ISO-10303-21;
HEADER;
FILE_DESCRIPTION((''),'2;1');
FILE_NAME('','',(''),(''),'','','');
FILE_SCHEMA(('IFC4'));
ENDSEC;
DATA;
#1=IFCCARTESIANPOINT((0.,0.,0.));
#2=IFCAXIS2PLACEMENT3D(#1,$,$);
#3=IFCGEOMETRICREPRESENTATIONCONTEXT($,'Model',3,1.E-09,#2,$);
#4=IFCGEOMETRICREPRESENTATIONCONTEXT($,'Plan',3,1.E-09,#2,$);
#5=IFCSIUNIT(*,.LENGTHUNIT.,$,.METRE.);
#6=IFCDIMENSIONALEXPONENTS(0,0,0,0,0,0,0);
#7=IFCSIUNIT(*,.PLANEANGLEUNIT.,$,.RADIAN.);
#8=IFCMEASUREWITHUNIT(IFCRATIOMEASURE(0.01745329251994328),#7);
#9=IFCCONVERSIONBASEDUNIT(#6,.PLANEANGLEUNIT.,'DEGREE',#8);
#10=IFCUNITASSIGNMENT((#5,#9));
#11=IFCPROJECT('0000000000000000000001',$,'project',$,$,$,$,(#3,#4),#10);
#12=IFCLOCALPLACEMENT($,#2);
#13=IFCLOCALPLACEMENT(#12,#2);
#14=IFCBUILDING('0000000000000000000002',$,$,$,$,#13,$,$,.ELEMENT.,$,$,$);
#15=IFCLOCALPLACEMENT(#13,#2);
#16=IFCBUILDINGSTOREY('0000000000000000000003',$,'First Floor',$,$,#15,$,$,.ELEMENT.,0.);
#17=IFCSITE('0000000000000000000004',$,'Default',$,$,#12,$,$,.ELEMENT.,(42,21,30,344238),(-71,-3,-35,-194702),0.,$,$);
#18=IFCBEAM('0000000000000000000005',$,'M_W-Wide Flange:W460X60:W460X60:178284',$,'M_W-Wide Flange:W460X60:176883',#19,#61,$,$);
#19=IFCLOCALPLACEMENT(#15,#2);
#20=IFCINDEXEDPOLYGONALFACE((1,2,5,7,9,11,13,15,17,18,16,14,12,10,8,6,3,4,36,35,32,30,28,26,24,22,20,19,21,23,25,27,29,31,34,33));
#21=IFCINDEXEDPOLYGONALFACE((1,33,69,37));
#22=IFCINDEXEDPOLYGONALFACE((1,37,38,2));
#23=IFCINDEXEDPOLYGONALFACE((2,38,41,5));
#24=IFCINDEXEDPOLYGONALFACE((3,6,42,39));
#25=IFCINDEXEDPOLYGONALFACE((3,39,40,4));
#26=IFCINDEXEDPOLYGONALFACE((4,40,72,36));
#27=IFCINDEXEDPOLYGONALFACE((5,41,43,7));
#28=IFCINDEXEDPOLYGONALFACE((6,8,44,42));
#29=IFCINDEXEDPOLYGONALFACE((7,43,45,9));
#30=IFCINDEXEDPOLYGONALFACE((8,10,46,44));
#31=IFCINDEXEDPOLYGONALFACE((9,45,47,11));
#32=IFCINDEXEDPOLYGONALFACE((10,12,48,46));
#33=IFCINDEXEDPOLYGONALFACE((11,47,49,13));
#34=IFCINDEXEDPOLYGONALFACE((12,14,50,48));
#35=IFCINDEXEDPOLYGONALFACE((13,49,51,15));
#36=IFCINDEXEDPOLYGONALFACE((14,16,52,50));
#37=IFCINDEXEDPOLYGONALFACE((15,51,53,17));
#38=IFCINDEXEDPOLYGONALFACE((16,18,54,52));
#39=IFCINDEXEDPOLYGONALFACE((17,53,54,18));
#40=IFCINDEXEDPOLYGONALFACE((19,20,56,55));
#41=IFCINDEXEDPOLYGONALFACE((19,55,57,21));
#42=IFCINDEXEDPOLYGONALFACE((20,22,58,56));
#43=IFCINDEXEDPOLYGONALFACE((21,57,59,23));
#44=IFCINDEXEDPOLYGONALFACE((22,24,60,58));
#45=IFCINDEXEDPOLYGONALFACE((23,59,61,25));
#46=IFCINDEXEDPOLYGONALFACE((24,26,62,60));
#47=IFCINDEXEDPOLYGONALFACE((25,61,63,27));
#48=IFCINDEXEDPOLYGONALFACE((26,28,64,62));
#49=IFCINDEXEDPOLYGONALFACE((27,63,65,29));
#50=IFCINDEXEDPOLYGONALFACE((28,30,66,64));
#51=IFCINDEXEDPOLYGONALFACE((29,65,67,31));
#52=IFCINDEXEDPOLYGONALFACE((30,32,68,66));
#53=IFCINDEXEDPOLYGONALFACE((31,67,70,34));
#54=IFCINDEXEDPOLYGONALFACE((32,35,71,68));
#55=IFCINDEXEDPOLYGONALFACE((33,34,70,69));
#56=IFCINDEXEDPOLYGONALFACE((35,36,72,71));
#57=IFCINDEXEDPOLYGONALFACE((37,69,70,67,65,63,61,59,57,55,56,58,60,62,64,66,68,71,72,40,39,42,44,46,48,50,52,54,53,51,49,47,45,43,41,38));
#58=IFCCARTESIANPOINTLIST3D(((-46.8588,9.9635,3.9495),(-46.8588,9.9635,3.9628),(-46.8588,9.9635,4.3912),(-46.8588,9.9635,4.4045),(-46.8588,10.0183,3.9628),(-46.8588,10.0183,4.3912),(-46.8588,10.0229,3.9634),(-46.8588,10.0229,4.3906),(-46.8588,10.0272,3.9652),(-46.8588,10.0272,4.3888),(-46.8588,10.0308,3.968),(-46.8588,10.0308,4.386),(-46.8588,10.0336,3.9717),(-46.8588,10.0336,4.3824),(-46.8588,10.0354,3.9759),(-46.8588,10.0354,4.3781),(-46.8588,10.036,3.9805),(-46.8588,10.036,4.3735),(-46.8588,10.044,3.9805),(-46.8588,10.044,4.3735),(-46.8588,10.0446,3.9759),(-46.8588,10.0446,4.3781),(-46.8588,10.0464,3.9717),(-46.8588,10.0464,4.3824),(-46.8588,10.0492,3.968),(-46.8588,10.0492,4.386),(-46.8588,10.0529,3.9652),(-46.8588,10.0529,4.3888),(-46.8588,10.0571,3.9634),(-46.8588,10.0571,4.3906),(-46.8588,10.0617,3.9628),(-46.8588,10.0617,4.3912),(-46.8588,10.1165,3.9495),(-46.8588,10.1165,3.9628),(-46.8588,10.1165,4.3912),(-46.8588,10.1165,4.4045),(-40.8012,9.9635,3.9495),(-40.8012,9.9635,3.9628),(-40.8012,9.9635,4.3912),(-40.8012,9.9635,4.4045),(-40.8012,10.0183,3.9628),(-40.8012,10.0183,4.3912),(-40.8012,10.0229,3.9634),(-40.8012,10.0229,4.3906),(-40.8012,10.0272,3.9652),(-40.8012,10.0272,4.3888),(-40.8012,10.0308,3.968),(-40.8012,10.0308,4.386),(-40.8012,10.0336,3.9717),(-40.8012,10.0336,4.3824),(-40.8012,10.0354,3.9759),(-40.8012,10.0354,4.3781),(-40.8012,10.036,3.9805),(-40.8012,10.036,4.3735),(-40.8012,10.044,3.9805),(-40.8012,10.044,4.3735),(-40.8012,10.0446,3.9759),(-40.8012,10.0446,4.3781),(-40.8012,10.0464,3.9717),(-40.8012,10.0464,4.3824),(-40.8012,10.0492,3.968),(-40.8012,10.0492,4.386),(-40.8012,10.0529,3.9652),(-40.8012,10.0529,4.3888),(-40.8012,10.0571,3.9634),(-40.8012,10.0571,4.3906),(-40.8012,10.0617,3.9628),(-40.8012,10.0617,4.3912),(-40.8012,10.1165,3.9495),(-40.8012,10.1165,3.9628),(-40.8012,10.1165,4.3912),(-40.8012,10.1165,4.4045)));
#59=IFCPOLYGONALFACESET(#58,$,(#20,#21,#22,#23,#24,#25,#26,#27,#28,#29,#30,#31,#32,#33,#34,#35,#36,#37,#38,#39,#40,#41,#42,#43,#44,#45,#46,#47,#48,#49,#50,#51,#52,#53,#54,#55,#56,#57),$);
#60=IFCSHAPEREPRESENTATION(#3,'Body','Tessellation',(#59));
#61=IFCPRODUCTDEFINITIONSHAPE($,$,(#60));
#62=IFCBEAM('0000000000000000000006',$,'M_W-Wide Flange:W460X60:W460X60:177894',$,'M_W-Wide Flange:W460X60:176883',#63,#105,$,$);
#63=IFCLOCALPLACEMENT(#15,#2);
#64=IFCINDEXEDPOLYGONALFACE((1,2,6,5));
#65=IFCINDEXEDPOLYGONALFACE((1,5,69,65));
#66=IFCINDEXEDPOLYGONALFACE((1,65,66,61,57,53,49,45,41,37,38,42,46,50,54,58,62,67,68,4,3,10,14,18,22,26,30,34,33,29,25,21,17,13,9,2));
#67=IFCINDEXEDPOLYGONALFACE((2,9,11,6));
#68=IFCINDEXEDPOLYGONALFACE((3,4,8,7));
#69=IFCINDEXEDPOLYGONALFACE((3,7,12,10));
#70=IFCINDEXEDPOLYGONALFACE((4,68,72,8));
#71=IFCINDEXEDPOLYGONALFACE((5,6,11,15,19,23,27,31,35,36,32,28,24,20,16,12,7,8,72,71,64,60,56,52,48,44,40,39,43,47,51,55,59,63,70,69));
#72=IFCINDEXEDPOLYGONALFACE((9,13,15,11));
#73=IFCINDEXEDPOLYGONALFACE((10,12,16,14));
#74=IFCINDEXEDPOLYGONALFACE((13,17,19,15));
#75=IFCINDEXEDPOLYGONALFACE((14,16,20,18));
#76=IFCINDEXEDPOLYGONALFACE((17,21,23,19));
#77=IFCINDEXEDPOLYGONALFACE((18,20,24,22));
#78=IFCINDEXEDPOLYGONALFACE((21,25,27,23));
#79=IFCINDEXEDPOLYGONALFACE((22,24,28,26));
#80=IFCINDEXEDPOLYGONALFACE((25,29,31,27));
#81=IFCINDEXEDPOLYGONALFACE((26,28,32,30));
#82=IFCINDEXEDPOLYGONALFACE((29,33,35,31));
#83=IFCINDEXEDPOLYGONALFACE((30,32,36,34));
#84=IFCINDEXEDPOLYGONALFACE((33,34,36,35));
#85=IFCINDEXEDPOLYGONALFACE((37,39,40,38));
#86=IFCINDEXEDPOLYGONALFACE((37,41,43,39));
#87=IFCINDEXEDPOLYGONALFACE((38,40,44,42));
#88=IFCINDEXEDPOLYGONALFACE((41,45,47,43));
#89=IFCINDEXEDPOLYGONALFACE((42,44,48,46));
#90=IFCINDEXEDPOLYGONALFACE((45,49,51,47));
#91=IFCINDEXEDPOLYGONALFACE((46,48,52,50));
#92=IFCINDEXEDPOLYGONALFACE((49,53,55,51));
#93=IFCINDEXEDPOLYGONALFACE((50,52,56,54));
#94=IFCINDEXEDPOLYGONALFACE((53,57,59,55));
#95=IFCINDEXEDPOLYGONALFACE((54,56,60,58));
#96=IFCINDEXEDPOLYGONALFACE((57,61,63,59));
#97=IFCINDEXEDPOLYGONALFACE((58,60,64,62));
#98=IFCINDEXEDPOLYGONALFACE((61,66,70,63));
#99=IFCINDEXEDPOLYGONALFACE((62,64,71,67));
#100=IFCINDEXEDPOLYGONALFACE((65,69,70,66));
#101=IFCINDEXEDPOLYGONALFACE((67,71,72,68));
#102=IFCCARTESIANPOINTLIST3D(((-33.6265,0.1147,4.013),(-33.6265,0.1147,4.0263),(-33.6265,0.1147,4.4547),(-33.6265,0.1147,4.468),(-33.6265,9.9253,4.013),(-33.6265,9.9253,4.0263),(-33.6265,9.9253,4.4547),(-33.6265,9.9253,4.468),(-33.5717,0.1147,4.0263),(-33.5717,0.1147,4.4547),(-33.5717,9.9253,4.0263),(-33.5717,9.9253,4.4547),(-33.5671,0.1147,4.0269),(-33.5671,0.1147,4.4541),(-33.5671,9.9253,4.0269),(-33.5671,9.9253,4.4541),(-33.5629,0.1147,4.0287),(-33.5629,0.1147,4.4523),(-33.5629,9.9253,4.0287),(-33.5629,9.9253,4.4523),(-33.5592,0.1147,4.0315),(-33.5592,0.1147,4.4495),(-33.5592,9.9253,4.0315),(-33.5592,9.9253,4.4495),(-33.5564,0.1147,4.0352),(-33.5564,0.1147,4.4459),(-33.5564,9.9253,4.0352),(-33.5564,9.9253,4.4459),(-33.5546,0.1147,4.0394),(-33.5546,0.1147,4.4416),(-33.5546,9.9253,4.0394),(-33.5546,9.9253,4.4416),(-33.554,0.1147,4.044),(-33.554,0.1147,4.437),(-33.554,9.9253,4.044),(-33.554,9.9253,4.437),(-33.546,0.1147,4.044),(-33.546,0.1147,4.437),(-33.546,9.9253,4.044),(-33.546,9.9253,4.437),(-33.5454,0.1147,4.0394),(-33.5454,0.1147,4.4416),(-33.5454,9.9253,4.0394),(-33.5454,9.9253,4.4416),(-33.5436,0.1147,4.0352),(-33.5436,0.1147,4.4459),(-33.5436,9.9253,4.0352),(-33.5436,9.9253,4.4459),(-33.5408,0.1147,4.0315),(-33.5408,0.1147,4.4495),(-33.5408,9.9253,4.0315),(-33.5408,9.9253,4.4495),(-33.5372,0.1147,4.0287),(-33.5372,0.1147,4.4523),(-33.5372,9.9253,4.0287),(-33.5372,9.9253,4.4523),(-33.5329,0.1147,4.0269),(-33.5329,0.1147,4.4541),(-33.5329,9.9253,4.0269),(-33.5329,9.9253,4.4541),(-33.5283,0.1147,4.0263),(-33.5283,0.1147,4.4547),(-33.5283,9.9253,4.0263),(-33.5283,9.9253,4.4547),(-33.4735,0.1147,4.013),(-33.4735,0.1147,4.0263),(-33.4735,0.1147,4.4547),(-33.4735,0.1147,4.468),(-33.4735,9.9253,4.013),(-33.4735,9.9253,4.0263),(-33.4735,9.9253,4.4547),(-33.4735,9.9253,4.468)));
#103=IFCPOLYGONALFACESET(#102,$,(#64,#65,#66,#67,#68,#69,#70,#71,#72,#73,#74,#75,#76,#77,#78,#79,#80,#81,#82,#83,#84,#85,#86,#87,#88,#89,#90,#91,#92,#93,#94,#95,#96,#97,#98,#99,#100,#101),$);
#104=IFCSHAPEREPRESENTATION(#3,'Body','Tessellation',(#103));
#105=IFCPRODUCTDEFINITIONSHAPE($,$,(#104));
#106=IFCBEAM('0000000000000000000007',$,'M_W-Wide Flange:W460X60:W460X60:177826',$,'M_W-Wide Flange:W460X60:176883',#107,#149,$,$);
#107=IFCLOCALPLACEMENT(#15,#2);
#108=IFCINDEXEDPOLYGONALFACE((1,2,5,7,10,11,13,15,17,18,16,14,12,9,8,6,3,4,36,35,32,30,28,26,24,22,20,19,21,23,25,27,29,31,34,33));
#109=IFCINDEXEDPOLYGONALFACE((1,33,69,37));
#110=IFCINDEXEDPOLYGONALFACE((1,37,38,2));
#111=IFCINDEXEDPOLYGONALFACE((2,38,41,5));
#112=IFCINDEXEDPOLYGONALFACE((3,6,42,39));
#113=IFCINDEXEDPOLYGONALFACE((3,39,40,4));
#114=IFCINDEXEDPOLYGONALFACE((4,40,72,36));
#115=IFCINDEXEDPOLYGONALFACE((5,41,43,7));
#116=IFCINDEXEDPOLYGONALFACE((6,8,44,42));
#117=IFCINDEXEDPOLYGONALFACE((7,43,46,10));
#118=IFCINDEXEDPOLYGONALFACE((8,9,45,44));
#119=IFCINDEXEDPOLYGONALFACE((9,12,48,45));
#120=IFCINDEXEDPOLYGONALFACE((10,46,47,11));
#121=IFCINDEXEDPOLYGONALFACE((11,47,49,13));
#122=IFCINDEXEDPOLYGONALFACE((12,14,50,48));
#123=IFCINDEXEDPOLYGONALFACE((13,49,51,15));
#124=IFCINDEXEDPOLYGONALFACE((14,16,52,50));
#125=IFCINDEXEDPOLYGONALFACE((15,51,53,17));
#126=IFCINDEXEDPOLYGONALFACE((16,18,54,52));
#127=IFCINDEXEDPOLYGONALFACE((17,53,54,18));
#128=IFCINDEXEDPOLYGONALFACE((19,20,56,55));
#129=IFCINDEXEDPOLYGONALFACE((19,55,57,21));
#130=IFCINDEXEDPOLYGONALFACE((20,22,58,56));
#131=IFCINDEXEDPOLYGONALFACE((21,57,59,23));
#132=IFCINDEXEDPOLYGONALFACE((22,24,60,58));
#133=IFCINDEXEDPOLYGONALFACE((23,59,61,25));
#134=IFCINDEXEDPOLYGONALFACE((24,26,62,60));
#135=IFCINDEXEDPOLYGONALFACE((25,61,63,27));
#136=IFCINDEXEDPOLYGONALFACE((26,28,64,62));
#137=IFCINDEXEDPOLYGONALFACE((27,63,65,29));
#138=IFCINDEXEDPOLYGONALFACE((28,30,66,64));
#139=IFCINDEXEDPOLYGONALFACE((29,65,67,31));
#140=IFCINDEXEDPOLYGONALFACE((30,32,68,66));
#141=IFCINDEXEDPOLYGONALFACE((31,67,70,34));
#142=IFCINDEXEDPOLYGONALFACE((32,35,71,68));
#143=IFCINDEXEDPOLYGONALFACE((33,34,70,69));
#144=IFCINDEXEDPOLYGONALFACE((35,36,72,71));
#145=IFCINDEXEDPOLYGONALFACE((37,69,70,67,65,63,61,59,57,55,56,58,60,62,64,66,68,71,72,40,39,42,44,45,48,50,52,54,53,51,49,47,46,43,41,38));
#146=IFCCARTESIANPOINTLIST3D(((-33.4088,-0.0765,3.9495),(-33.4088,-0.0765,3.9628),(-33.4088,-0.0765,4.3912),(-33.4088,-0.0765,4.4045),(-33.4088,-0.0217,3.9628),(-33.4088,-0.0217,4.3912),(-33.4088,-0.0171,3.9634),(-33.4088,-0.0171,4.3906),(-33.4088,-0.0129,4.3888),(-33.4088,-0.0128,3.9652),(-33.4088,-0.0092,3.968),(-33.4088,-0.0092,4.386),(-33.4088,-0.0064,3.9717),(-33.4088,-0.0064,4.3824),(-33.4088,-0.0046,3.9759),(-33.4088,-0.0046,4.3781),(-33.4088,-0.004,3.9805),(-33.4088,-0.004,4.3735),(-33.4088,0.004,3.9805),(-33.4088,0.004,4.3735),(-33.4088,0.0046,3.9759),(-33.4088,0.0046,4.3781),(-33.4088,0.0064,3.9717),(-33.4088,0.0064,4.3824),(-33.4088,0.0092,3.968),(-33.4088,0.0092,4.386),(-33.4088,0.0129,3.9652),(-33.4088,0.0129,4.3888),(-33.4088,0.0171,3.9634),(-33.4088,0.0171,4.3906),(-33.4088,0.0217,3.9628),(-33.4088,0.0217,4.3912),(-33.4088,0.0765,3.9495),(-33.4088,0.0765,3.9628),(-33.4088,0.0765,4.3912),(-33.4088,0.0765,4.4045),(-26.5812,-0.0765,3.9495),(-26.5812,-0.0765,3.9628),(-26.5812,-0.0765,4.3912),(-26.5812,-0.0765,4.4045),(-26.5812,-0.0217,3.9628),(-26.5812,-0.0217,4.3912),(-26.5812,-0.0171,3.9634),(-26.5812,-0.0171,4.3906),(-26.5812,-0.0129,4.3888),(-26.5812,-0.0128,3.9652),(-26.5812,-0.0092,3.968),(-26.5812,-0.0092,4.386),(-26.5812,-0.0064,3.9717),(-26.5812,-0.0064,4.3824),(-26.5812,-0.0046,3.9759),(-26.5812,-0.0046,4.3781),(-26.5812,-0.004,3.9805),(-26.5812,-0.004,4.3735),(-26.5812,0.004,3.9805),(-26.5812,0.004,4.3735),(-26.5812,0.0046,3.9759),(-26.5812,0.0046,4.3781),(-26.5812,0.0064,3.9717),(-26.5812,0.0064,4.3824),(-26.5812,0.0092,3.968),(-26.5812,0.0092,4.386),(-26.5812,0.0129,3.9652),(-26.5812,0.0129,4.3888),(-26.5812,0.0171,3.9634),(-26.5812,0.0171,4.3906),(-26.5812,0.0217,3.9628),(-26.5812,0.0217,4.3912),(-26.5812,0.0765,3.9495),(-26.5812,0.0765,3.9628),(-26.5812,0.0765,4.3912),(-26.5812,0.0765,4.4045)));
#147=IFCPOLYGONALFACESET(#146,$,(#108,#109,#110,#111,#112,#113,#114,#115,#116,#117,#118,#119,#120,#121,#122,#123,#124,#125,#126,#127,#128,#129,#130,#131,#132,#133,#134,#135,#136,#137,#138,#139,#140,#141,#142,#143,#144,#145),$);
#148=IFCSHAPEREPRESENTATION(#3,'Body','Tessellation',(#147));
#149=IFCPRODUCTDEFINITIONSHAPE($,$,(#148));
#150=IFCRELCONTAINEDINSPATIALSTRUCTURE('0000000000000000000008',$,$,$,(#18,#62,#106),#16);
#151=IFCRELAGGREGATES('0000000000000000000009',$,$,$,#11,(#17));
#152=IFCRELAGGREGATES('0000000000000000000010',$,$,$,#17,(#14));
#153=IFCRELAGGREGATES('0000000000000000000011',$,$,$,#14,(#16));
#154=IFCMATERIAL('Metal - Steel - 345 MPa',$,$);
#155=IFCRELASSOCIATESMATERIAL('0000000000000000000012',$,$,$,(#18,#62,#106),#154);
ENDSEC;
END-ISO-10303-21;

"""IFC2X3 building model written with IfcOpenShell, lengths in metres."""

from ifc_helpers import new_model, entity, si_unit, converted_unit, frame, frame_2d, origin, place, context, project, spatial, polyline, circle_curve, parameter, trimmed, segment, composite_curve, outline, extrude, material, element, save


model = new_model("IFC2X3")

# Units and contexts
model_context = context("Model", 3, precision=1e-09, world=origin())
plan_context = context("Plan", 3, precision=1e-09, world=origin())
ifc_project = project(units=[si_unit("LENGTHUNIT", "METRE"), converted_unit("PLANEANGLEUNIT", "DEGREE", entity("IfcRatioMeasure", 0.01745329251994328), si_unit("PLANEANGLEUNIT", "RADIAN"), dimensions=[0, 0, 0, 0, 0, 0, 0])], contexts=[model_context, plan_context])

# Site, building, storey
site_placement = place(None, origin())
site = spatial("IfcSite", under=ifc_project, at=site_placement, Name="Default", CompositionType="ELEMENT", RefLatitude=(42, 21, 30, 344238), RefLongitude=(-71, -3, -35, -194702), RefElevation=0.0)
building_placement = place(site_placement, origin())
building = spatial("IfcBuilding", under=site, at=building_placement, CompositionType="ELEMENT")
storey_placement = place(building_placement, origin())
storey = spatial("IfcBuildingStorey", under=building, at=storey_placement, Name="First Floor", CompositionType="ELEMENT", Elevation=0.0)

# Beams
ifc_material_1 = material(Name="Metal - Steel - 345 MPa")
beam_1_placement = place(storey_placement, frame((-47.0022, 10.04, 4.4045), z_axis=(0.0, 0.0, 1.0), x_axis=(0.0, -1.0, 0.0)))
element("IfcBeam", 1, at=beam_1_placement, inside=storey, material=ifc_material_1, Name="M_W-Wide Flange:W460X60:W460X60:178284", ObjectType="M_W-Wide Flange:W460X60:176883", context=model_context, shape_type="SweptSolid", body=[
    extrude(outline(composite_curve([segment(polyline([(-0.0765, -0.2142), (-0.0765, -0.2275)]), True, "CONTINUOUS"), segment(polyline([(-0.0765, -0.2275), (0.0765, -0.2275)]), True, "CONTINUOUS"), segment(polyline([(0.0765, -0.2275), (0.0765, -0.2142)]), True, "CONTINUOUS"), segment(polyline([(0.0765, -0.2142), (0.0217, -0.2142)]), True, "CONTINUOUS"), segment(trimmed(circle_curve(frame_2d((0.0217, -0.1965), x_axis=(1.0, 0.0)), 0.0177), [parameter(180.0)], [parameter(270.0)], True, "PARAMETER"), False, "CONTINUOUS"), segment(polyline([(0.004, -0.1965), (0.004, 0.1965)]), True, "CONTINUOUS"), segment(trimmed(circle_curve(frame_2d((0.0217, 0.1965), x_axis=(1.0, 0.0)), 0.0177), [parameter(90.0)], [parameter(180.0)], True, "PARAMETER"), False, "CONTINUOUS"), segment(polyline([(0.0217, 0.2142), (0.0765, 0.2142)]), True, "CONTINUOUS"), segment(polyline([(0.0765, 0.2142), (0.0765, 0.2275)]), True, "CONTINUOUS"), segment(polyline([(0.0765, 0.2275), (-0.0765, 0.2275)]), True, "CONTINUOUS"), segment(polyline([(-0.0765, 0.2275), (-0.0765, 0.2142)]), True, "CONTINUOUS"), segment(polyline([(-0.0765, 0.2142), (-0.0217, 0.2142)]), True, "CONTINUOUS"), segment(trimmed(circle_curve(frame_2d((-0.0217, 0.1965), x_axis=(1.0, 0.0)), 0.0177), [parameter(360.0)], [parameter(90.0)], True, "PARAMETER"), False, "CONTINUOUS"), segment(polyline([(-0.004, 0.1965), (-0.004, -0.1965)]), True, "CONTINUOUS"), segment(trimmed(circle_curve(frame_2d((-0.0217, -0.1965), x_axis=(1.0, 0.0)), 0.0177), [parameter(270.0)], [parameter(0.0)], True, "PARAMETER"), False, "CONTINUOUS"), segment(polyline([(-0.0217, -0.2142), (-0.0765, -0.2142)]), True, "CONTINUOUS")], self_intersect=False)), frame((0.0, 0.1434, -0.2275), z_axis=(0.0, -1.0, 0.0), x_axis=(1.0, 0.0, 0.0)), (0.0, 0.0, -1.0), 6.0576),
])
beam_2_placement = place(storey_placement, frame((-33.55, -0.0014, 4.468)))
element("IfcBeam", 2, at=beam_2_placement, inside=storey, material=ifc_material_1, Name="M_W-Wide Flange:W460X60:W460X60:177894", ObjectType="M_W-Wide Flange:W460X60:176883", context=model_context, shape_type="SweptSolid", body=[
    extrude(outline(composite_curve([segment(polyline([(-0.0765, -0.2142), (-0.0765, -0.2275)]), True, "CONTINUOUS"), segment(polyline([(-0.0765, -0.2275), (0.0765, -0.2275)]), True, "CONTINUOUS"), segment(polyline([(0.0765, -0.2275), (0.0765, -0.2142)]), True, "CONTINUOUS"), segment(polyline([(0.0765, -0.2142), (0.0217, -0.2142)]), True, "CONTINUOUS"), segment(trimmed(circle_curve(frame_2d((0.0217, -0.1965), x_axis=(0.0, -1.0)), 0.0177), [parameter(270.0)], [parameter(360.0)], True, "PARAMETER"), False, "CONTINUOUS"), segment(polyline([(0.004, -0.1965), (0.004, 0.1965)]), True, "CONTINUOUS"), segment(trimmed(circle_curve(frame_2d((0.0217, 0.1965), x_axis=(-1.0, 0.0)), 0.0177), [parameter(270.0)], [parameter(360.0)], True, "PARAMETER"), False, "CONTINUOUS"), segment(polyline([(0.0217, 0.2142), (0.0765, 0.2142)]), True, "CONTINUOUS"), segment(polyline([(0.0765, 0.2142), (0.0765, 0.2275)]), True, "CONTINUOUS"), segment(polyline([(0.0765, 0.2275), (-0.0765, 0.2275)]), True, "CONTINUOUS"), segment(polyline([(-0.0765, 0.2275), (-0.0765, 0.2142)]), True, "CONTINUOUS"), segment(polyline([(-0.0765, 0.2142), (-0.0217, 0.2142)]), True, "CONTINUOUS"), segment(trimmed(circle_curve(frame_2d((-0.0217, 0.1965), x_axis=(0.0, 1.0)), 0.0177), [parameter(270.0)], [parameter(360.0)], True, "PARAMETER"), False, "CONTINUOUS"), segment(polyline([(-0.004, 0.1965), (-0.004, -0.1965)]), True, "CONTINUOUS"), segment(trimmed(circle_curve(frame_2d((-0.0217, -0.1965), x_axis=(1.0, 0.0)), 0.0177), [parameter(270.0)], [parameter(0.0)], True, "PARAMETER"), False, "CONTINUOUS"), segment(polyline([(-0.0217, -0.2142), (-0.0765, -0.2142)]), True, "CONTINUOUS")], self_intersect=False)), frame((0.0, 0.1161, -0.2275), z_axis=(0.0, -1.0, 0.0), x_axis=(1.0, 0.0, 0.0)), (0.0, 0.0, -1.0), 9.8106),
])
beam_3_placement = place(storey_placement, frame((-33.5519, 0.0, 4.4045), z_axis=(0.0, 0.0, 1.0), x_axis=(0.0, -1.0, 0.0)))
element("IfcBeam", 3, at=beam_3_placement, inside=storey, material=ifc_material_1, Name="M_W-Wide Flange:W460X60:W460X60:177826", ObjectType="M_W-Wide Flange:W460X60:176883", context=model_context, shape_type="SweptSolid", body=[
    extrude(outline(composite_curve([segment(polyline([(-0.0765, -0.2142), (-0.0765, -0.2275)]), True, "CONTINUOUS"), segment(polyline([(-0.0765, -0.2275), (0.0765, -0.2275)]), True, "CONTINUOUS"), segment(polyline([(0.0765, -0.2275), (0.0765, -0.2142)]), True, "CONTINUOUS"), segment(polyline([(0.0765, -0.2142), (0.0217, -0.2142)]), True, "CONTINUOUS"), segment(trimmed(circle_curve(frame_2d((0.0217, -0.1965), x_axis=(0.0, -1.0)), 0.0177), [parameter(270.0)], [parameter(360.0)], True, "PARAMETER"), False, "CONTINUOUS"), segment(polyline([(0.004, -0.1965), (0.004, 0.1965)]), True, "CONTINUOUS"), segment(trimmed(circle_curve(frame_2d((0.0217, 0.1965), x_axis=(-1.0, 0.0)), 0.0177), [parameter(270.0)], [parameter(360.0)], True, "PARAMETER"), False, "CONTINUOUS"), segment(polyline([(0.0217, 0.2142), (0.0765, 0.2142)]), True, "CONTINUOUS"), segment(polyline([(0.0765, 0.2142), (0.0765, 0.2275)]), True, "CONTINUOUS"), segment(polyline([(0.0765, 0.2275), (-0.0765, 0.2275)]), True, "CONTINUOUS"), segment(polyline([(-0.0765, 0.2275), (-0.0765, 0.2142)]), True, "CONTINUOUS"), segment(polyline([(-0.0765, 0.2142), (-0.0217, 0.2142)]), True, "CONTINUOUS"), segment(trimmed(circle_curve(frame_2d((-0.0217, 0.1965), x_axis=(0.0, 1.0)), 0.0177), [parameter(270.0)], [parameter(360.0)], True, "PARAMETER"), False, "CONTINUOUS"), segment(polyline([(-0.004, 0.1965), (-0.004, -0.1965)]), True, "CONTINUOUS"), segment(trimmed(circle_curve(frame_2d((-0.0217, -0.1965), x_axis=(1.0, 0.0)), 0.0177), [parameter(270.0)], [parameter(0.0)], True, "PARAMETER"), False, "CONTINUOUS"), segment(polyline([(-0.0217, -0.2142), (-0.0765, -0.2142)]), True, "CONTINUOUS")], self_intersect=False)), frame((0.0, 0.1431, -0.2275), z_axis=(0.0, -1.0, 0.0), x_axis=(1.0, 0.0, 0.0)), (0.0, 0.0, -1.0), 6.8276),
])

save(model, "model.ifc")
